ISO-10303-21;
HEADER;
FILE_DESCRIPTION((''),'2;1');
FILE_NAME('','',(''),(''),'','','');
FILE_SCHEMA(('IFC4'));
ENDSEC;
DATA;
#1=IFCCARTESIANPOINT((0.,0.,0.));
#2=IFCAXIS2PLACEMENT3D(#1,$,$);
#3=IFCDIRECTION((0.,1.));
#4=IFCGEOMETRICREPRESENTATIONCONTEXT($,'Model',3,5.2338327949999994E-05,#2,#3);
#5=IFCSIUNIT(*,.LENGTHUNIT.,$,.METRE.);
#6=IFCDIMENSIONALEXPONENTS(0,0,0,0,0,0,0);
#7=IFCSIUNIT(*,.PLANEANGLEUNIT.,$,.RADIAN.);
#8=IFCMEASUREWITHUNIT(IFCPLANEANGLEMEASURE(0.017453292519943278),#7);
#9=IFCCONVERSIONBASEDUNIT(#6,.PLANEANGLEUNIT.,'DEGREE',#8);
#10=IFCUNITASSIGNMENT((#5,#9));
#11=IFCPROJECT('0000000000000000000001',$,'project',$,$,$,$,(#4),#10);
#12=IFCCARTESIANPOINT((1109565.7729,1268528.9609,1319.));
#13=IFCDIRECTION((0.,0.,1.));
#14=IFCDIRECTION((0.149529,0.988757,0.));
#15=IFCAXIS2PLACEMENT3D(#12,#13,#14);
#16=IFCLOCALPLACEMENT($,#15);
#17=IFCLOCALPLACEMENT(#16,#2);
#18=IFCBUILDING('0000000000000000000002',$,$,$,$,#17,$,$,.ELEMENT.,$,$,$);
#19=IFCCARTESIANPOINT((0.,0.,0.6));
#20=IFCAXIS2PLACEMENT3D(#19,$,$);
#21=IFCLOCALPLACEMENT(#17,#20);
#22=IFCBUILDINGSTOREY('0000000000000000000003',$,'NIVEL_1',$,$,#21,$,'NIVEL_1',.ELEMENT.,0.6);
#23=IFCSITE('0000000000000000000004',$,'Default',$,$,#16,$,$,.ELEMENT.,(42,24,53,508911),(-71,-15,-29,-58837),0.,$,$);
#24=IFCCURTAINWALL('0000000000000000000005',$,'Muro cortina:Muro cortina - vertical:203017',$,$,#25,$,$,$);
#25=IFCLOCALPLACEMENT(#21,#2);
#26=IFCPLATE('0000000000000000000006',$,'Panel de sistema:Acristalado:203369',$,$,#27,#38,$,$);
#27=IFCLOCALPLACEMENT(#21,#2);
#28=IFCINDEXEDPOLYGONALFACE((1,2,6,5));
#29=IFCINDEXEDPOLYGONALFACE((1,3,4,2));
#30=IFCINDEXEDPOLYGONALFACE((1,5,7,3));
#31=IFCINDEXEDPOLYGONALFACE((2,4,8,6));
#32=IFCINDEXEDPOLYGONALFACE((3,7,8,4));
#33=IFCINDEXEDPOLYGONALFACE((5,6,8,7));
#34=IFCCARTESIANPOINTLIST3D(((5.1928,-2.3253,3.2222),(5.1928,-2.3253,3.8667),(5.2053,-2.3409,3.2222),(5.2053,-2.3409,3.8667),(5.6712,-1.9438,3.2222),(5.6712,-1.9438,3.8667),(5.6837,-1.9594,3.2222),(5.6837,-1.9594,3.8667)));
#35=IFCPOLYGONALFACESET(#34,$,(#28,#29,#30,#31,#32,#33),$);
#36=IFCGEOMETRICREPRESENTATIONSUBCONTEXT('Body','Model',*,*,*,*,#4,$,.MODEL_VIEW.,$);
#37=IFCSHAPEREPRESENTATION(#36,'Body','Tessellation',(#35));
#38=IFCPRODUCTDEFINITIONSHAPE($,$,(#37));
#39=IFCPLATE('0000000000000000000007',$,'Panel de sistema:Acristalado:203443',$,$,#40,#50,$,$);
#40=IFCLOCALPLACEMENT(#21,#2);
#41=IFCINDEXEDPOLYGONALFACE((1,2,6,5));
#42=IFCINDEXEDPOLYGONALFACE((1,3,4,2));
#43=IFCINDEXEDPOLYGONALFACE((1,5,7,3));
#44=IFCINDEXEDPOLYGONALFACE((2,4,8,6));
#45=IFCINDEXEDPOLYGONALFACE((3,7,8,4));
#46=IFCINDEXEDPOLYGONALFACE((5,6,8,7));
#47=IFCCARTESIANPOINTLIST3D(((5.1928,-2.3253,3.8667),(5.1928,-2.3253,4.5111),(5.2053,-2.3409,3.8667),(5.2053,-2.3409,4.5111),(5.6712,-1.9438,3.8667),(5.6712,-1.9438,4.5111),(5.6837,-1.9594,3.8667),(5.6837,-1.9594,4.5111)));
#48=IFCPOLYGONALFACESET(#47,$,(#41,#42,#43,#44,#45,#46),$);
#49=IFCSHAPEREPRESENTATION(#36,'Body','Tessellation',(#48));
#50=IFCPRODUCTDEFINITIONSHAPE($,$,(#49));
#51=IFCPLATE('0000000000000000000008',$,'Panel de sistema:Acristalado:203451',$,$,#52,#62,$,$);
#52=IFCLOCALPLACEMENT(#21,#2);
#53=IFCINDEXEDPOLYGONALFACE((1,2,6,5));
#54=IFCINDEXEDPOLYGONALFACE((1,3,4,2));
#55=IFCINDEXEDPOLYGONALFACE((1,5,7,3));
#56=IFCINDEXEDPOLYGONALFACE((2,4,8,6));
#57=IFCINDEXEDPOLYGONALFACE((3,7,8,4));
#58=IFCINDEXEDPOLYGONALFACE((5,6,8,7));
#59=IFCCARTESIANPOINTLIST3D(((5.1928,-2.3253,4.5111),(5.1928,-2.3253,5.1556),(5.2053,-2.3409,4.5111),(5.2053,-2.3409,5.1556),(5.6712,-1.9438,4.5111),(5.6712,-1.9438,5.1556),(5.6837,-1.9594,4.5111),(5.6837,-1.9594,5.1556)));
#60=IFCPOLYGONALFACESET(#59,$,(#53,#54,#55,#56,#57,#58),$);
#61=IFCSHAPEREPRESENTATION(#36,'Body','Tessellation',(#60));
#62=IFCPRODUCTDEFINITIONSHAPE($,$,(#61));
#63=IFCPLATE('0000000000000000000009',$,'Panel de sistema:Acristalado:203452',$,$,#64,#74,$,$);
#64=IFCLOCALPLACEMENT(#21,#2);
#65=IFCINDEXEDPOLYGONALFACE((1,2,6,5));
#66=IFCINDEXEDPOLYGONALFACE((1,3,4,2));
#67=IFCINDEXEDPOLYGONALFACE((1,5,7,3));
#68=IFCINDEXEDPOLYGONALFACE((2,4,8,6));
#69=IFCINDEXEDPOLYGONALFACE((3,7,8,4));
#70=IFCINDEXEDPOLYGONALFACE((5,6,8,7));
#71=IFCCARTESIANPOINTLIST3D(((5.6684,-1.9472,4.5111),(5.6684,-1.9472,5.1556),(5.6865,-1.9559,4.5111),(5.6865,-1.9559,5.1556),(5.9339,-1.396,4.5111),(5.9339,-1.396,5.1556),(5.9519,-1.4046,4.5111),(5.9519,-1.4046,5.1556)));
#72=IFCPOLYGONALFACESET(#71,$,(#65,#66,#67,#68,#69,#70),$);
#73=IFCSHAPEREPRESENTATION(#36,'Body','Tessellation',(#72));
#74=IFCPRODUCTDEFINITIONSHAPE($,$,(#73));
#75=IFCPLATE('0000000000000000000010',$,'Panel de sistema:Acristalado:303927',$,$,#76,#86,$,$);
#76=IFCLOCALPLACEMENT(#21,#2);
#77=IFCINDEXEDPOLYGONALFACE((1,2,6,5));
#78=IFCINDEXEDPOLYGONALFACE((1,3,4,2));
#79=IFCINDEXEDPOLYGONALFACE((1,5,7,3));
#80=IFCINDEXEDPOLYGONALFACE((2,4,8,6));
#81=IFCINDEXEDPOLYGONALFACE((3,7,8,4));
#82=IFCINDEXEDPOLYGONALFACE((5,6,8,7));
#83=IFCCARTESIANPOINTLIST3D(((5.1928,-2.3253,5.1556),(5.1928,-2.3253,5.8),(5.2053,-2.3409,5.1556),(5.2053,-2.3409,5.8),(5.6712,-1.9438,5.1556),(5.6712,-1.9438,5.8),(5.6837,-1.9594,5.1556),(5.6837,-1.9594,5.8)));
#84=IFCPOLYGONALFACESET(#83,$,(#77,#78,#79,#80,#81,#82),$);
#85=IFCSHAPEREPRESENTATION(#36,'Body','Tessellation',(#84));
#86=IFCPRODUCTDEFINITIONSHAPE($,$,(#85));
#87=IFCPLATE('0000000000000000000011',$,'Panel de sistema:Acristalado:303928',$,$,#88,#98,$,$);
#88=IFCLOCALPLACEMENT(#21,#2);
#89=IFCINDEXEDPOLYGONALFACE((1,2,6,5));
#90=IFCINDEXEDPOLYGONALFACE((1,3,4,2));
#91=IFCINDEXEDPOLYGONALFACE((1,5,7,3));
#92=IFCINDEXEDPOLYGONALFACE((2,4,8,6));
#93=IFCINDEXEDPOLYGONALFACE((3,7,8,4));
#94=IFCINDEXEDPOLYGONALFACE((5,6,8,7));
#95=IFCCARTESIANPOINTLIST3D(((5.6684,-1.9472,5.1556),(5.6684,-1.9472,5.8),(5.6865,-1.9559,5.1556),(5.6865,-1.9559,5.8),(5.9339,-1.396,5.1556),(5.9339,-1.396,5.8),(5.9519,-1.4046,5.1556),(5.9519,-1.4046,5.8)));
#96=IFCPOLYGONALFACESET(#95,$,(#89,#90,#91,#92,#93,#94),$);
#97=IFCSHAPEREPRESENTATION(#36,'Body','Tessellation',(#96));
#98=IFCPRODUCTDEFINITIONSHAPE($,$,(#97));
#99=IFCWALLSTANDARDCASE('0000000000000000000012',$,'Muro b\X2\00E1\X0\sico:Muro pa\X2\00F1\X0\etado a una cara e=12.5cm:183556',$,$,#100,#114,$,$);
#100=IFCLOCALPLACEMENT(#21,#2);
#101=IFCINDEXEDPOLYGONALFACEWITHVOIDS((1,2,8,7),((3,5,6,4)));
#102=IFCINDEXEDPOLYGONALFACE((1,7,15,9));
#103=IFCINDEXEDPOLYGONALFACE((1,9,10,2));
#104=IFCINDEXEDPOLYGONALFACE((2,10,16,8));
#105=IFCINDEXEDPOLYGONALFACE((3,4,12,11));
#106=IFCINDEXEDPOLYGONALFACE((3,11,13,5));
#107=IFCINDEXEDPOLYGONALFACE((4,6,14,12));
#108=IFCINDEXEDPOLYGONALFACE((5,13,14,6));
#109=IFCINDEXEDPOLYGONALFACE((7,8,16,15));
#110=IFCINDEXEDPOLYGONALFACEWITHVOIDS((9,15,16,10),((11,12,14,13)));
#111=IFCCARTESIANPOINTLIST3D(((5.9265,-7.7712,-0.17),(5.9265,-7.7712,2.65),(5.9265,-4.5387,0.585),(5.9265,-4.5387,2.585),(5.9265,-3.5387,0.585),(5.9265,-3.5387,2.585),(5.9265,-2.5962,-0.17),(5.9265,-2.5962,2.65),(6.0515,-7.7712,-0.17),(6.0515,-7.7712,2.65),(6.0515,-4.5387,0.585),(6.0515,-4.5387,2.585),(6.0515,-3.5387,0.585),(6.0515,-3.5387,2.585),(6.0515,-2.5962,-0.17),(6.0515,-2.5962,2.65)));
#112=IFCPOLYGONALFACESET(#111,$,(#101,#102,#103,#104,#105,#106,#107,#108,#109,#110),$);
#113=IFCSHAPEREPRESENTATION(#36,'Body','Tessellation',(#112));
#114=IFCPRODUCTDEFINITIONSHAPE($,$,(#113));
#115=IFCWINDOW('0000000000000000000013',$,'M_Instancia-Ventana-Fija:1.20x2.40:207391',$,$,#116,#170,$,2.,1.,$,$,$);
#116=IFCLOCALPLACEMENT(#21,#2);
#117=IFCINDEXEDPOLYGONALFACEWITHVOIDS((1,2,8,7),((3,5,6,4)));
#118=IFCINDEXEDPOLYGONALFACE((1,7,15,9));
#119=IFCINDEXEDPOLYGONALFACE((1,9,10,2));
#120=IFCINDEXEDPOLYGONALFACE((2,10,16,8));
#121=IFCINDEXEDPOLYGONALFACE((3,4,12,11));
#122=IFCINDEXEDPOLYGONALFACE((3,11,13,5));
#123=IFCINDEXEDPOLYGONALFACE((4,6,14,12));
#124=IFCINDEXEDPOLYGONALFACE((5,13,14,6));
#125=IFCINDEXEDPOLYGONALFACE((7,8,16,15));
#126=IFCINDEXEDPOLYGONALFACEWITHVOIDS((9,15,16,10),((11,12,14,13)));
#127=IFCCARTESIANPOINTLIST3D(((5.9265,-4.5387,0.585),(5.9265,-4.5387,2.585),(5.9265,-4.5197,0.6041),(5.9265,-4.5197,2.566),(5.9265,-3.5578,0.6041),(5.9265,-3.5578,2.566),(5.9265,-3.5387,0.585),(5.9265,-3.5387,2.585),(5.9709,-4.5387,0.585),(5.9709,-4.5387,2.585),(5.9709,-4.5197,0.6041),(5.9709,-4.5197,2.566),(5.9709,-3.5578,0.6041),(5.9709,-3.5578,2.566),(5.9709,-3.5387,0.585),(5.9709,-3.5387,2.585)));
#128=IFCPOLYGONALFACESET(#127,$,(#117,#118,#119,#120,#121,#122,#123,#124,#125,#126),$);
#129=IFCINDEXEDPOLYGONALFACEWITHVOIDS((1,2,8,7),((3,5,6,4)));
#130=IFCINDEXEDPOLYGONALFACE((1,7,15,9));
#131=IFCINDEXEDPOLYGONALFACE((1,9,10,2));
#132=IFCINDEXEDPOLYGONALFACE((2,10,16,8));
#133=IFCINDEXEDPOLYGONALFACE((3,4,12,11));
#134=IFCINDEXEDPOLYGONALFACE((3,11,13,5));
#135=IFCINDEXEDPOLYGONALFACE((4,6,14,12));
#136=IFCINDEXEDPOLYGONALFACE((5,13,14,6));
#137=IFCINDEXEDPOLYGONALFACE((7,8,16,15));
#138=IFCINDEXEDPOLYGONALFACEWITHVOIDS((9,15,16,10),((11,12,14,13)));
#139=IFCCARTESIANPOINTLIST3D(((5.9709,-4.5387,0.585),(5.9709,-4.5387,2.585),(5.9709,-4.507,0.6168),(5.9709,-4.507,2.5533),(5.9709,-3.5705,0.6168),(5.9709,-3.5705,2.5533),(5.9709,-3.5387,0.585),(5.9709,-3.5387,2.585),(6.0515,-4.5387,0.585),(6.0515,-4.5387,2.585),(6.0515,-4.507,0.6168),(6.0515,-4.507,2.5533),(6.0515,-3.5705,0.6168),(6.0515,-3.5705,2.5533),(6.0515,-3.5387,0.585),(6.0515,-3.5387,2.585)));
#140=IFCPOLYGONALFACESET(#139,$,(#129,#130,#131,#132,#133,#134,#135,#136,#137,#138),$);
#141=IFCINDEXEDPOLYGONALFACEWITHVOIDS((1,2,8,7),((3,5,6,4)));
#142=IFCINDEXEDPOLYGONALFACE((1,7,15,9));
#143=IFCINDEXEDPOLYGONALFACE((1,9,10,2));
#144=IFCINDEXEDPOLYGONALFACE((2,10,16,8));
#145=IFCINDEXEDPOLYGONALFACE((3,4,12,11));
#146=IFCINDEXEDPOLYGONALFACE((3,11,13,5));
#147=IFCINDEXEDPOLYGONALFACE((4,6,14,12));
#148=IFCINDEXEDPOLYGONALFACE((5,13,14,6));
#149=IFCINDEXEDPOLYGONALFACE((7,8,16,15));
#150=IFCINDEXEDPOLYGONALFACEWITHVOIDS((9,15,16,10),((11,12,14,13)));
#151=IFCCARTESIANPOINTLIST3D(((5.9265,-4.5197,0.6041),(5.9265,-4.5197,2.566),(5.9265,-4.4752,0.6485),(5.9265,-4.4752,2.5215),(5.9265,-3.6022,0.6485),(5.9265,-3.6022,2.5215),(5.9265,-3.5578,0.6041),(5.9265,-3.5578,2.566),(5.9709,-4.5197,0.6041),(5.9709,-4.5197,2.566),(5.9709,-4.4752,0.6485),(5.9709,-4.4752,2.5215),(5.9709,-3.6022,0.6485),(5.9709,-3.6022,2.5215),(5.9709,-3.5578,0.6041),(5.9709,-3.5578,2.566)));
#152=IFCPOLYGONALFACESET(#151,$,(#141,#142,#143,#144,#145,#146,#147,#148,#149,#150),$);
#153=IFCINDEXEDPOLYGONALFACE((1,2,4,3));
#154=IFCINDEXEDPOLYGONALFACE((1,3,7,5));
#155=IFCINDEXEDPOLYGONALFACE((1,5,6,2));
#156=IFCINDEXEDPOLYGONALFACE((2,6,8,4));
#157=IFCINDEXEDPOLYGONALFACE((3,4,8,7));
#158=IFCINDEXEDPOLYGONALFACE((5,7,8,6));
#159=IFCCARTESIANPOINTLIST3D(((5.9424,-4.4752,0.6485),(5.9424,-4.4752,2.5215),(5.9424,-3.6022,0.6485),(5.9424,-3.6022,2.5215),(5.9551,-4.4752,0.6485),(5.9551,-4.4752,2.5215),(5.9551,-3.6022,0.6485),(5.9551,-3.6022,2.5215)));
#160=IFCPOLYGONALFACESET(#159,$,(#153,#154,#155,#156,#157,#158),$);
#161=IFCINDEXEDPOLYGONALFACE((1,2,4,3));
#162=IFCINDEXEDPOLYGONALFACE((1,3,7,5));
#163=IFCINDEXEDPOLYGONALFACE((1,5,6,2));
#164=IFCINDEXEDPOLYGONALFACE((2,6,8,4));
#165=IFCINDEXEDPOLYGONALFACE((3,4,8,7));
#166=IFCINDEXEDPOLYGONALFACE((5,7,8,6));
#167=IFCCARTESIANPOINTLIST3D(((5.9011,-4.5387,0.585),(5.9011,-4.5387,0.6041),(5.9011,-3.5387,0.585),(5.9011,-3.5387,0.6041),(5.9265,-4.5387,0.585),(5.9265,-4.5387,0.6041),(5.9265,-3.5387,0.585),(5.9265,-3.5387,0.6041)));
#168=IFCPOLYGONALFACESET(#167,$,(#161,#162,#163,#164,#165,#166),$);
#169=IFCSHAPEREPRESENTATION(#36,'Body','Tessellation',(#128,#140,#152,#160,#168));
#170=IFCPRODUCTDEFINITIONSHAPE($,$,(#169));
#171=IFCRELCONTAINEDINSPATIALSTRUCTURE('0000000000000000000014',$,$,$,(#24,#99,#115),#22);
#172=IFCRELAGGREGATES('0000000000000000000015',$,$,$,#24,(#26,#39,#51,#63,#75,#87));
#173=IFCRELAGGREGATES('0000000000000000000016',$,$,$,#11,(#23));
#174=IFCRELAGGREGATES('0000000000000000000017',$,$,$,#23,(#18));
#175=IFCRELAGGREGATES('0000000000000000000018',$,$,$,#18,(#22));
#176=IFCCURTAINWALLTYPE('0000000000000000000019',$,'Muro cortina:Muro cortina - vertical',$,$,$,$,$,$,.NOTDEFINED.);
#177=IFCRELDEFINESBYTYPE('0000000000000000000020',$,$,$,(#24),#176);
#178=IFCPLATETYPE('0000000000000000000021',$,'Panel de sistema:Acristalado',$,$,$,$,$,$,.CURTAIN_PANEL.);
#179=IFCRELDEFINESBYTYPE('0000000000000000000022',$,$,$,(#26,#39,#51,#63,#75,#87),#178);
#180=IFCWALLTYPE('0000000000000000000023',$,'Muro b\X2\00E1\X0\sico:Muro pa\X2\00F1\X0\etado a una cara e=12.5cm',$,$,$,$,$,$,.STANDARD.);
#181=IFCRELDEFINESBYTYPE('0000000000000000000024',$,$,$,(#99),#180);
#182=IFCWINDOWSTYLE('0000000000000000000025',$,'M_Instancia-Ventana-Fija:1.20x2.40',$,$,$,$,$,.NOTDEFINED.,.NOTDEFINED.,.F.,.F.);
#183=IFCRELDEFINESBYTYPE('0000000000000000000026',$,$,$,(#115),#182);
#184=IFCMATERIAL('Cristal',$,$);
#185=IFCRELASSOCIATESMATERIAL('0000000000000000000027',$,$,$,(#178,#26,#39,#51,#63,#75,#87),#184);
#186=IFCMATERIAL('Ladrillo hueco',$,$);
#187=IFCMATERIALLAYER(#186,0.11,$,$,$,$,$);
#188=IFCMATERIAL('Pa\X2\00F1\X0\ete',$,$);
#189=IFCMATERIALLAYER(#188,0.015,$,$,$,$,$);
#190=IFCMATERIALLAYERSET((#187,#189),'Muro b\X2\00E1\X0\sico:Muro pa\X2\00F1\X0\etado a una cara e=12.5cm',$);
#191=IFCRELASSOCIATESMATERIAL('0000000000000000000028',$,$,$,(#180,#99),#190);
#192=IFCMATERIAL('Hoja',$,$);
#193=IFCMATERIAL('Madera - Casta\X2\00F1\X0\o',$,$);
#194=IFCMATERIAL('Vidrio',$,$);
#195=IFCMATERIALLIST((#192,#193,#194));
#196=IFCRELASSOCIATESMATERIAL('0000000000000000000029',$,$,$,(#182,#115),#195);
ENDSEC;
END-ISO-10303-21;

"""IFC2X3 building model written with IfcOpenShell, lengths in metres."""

from ifc_helpers import new_model, entity, si_unit, converted_unit, direction, frame, frame_2d, origin, origin_2d_with_axis, place, context, subcontext, project, spatial, polyline, rectangle, outline, extrude, source, transform, mapped, material, material_list, layer, layer_set, layer_usage, type_object, type_shapes, element, fill, aggregate, save


model = new_model("IFC2X3")

# Units and contexts
model_context = context("Model", 3, precision=5.2338327949999994e-05, world=origin(), true_north=direction((0.0, 1.0)))
body_context = subcontext(model_context, "Body", "Model", "MODEL_VIEW")
ifc_project = project(units=[si_unit("LENGTHUNIT", "METRE"), converted_unit("PLANEANGLEUNIT", "DEGREE", entity("IfcPlaneAngleMeasure", 0.017453292519943278), si_unit("PLANEANGLEUNIT", "RADIAN"), dimensions=[0, 0, 0, 0, 0, 0, 0])], contexts=[model_context])

# Site, building, storey
site_placement = place(None, frame((1109565.7729, 1268528.9609, 1319.0), z_axis=(0.0, 0.0, 1.0), x_axis=(0.149529, 0.988757, 0.0)))
site = spatial("IfcSite", under=ifc_project, at=site_placement, Name="Default", CompositionType="ELEMENT", RefLatitude=(42, 24, 53, 508911), RefLongitude=(-71, -15, -29, -58837), RefElevation=0.0)
building_placement = place(site_placement, origin())
building = spatial("IfcBuilding", under=site, at=building_placement, CompositionType="ELEMENT")
storey_placement = place(building_placement, frame((0.0, 0.0, 0.6)))
storey = spatial("IfcBuildingStorey", under=building, at=storey_placement, Name="NIVEL_1", LongName="NIVEL_1", CompositionType="ELEMENT", Elevation=0.6)

# Curtain wall, plates
curtain_wall_type = type_object("IfcCurtainWallType", Name="Muro cortina:Muro cortina - vertical", PredefinedType="NOTDEFINED")
curtain_wall_1_placement = place(storey_placement, frame((0.0, 0.0, -0.6)))
curtain_wall_1 = element("IfcCurtainWall", 1, at=curtain_wall_1_placement, inside=storey, type_object=curtain_wall_type, Name="Muro cortina:Muro cortina - vertical:203017")
ifc_material_1 = material(Name="Cristal")
plate_type_1 = type_object("IfcPlateType", Name="Panel de sistema:Acristalado", PredefinedType="CURTAIN_PANEL", material=ifc_material_1)
shared_shape_1 = source(origin(), body_context, "Body", "SweptSolid", [
    extrude(rectangle(XDim=0.02, YDim=0.6119, at=frame_2d((0.0, 0.0), x_axis=(1.0, 0.0))), frame((0.0, 0.0, 0.0), z_axis=(0.0, 0.0, 1.0), x_axis=(0.0, 1.0, 0.0)), (0.0, 0.0, 1.0), 0.6444),
])
type_shapes(plate_type_1, [shared_shape_1])
plate_1_placement = place(curtain_wall_1_placement, frame((5.4383, -2.1423, 3.8222), z_axis=(0.0, 0.0, 1.0), x_axis=(0.781832, 0.62349, 0.0)))
plate_1 = element("IfcPlate", 2, at=plate_1_placement, type_object=plate_type_1, material=ifc_material_1, Name="Panel de sistema:Acristalado:203369", context=body_context, shape_type="MappedRepresentation", body=[
    mapped(shared_shape_1, transform((0.0, 0.0, 0.0), scale=1.0)),
])
plate_2_placement = place(curtain_wall_1_placement, frame((5.4383, -2.1423, 4.4667), z_axis=(0.0, 0.0, 1.0), x_axis=(0.781832, 0.62349, 0.0)))
plate_2 = element("IfcPlate", 3, at=plate_2_placement, type_object=plate_type_1, material=ifc_material_1, Name="Panel de sistema:Acristalado:203443", context=body_context, shape_type="MappedRepresentation", body=[
    mapped(shared_shape_1, transform((0.0, 0.0, 0.0), scale=1.0)),
])
plate_3_placement = place(curtain_wall_1_placement, frame((5.4383, -2.1423, 5.1111), z_axis=(0.0, 0.0, 1.0), x_axis=(0.781832, 0.62349, 0.0)))
plate_3 = element("IfcPlate", 4, at=plate_3_placement, type_object=plate_type_1, material=ifc_material_1, Name="Panel de sistema:Acristalado:203451", context=body_context, shape_type="MappedRepresentation", body=[
    mapped(shared_shape_1, transform((0.0, 0.0, 0.0), scale=1.0)),
])
plate_4_placement = place(curtain_wall_1_placement, frame((5.8102, -1.6759, 5.1111), z_axis=(0.0, 0.0, 1.0), x_axis=(0.433884, 0.900969, 0.0)))
plate_4 = element("IfcPlate", 5, at=plate_4_placement, type_object=plate_type_1, material=ifc_material_1, Name="Panel de sistema:Acristalado:203452", context=body_context, shape_type="MappedRepresentation", body=[
    mapped(shared_shape_1, transform((0.0, 0.0, 0.0), scale=1.0)),
])
plate_5_placement = place(curtain_wall_1_placement, frame((5.4383, -2.1423, 5.7556), z_axis=(0.0, 0.0, 1.0), x_axis=(0.781832, 0.62349, 0.0)))
plate_5 = element("IfcPlate", 6, at=plate_5_placement, type_object=plate_type_1, material=ifc_material_1, Name="Panel de sistema:Acristalado:303927", context=body_context, shape_type="MappedRepresentation", body=[
    mapped(shared_shape_1, transform((0.0, 0.0, 0.0), scale=1.0)),
])
plate_6_placement = place(curtain_wall_1_placement, frame((5.8102, -1.6759, 5.7556), z_axis=(0.0, 0.0, 1.0), x_axis=(0.433884, 0.900969, 0.0)))
plate_6 = element("IfcPlate", 7, at=plate_6_placement, type_object=plate_type_1, material=ifc_material_1, Name="Panel de sistema:Acristalado:303928", context=body_context, shape_type="MappedRepresentation", body=[
    mapped(shared_shape_1, transform((0.0, 0.0, 0.0), scale=1.0)),
])
aggregate(curtain_wall_1, [plate_1, plate_2, plate_3, plate_4, plate_5, plate_6])

# Wall, opening, window
ifc_material_2 = material(Name="Ladrillo hueco")
ifc_layer_1 = layer(ifc_material_2, 0.11)
ifc_material_3 = material(Name="Pañete")
ifc_layer_2 = layer(ifc_material_3, 0.015)
ifc_layer_set_1 = layer_set([ifc_layer_1, ifc_layer_2], Name="Muro básico:Muro pañetado a una cara e=12.5cm")
ifc_layer_usage_1 = layer_usage(ifc_layer_set_1, "AXIS2", "POSITIVE", -0.0625)
wall_type_1 = type_object("IfcWallType", Name="Muro básico:Muro pañetado a una cara e=12.5cm", PredefinedType="STANDARD", material=ifc_layer_set_1)
wall_1_placement = place(storey_placement, frame((5.989, -7.7712, -0.17), z_axis=(0.0, 0.0, 1.0), x_axis=(0.0, 1.0, 0.0)))
wall_1 = element("IfcWallStandardCase", 8, at=wall_1_placement, inside=storey, type_object=wall_type_1, material=ifc_layer_usage_1, Name="Muro básico:Muro pañetado a una cara e=12.5cm:183556", context=body_context, shape_type="SweptSolid", body=[
    extrude(rectangle(XDim=5.175, YDim=0.125, at=frame_2d((2.5875, 0.0), x_axis=(-1.0, 0.0))), origin(), (0.0, 0.0, 1.0), 2.82),
])
opening_1_placement = place(wall_1_placement, frame((3.2325, -0.0625, 0.755)))
opening_1 = element("IfcOpeningElement", 9, at=opening_1_placement, cuts=wall_1, ObjectType="Opening", context=body_context, shape_type="SweptSolid", body=[
    extrude(rectangle(XDim=2.0, YDim=1.0, at=frame_2d((1.0, 0.5), x_axis=(-1.0, 0.0))), frame((0.0, 0.0, 0.0), z_axis=(0.0, 1.0, 0.0), x_axis=(0.0, 0.0, 1.0)), (0.0, 0.0, 1.0), 0.125),
])
ifc_material_4 = material(Name="Hoja")
ifc_material_5 = material(Name="Madera - Castaño")
ifc_material_6 = material(Name="Vidrio")
ifc_material_list = material_list([ifc_material_4, ifc_material_5, ifc_material_6])
window_style = type_object("IfcWindowStyle", Name="M_Instancia-Ventana-Fija:1.20x2.40", ConstructionType="NOTDEFINED", OperationType="NOTDEFINED", ParameterTakesPrecedence=False, Sizeable=False, material=ifc_material_list)
shared_shape_2 = source(origin(), body_context, "Body", "SweptSolid", [
    extrude(outline(polyline([(-1.0, -0.5), (1.0, -0.5), (1.0, 0.5), (-1.0, 0.5), (-1.0, -0.5)]), holes=[polyline([(-0.9809, -0.4809), (-0.9809, 0.481), (0.981, 0.481), (0.981, -0.4809), (-0.9809, -0.4809)])]), frame((0.5, 0.0806, 1.0), z_axis=(0.0, 1.0, 0.0), x_axis=(0.0, 0.0, -1.0)), (0.0, 0.0, 1.0), 0.0444),
    extrude(outline(polyline([(-0.5, -1.0), (0.5, -1.0), (0.5, 1.0), (-0.5, 1.0), (-0.5, -1.0)]), holes=[polyline([(-0.4683, -0.9682), (-0.4683, 0.9683), (0.4682, 0.9683), (0.4682, -0.9682), (-0.4683, -0.9682)])]), frame((0.5, 0.0, 1.0), z_axis=(0.0, 1.0, 0.0), x_axis=(1.0, 0.0, 0.0)), (0.0, 0.0, 1.0), 0.0806),
    extrude(outline(polyline([(-0.4809, -0.981), (0.4809, -0.981), (0.4809, 0.981), (-0.4809, 0.981), (-0.4809, -0.981)]), holes=[polyline([(-0.4365, -0.9365), (-0.4365, 0.9365), (0.4365, 0.9365), (0.4365, -0.9365), (-0.4365, -0.9365)])]), frame((0.5, 0.0806, 1.0), z_axis=(0.0, 1.0, 0.0), x_axis=(1.0, 0.0, 0.0)), (0.0, 0.0, 1.0), 0.0444),
    extrude(rectangle(XDim=0.0127, YDim=0.873, at=frame_2d((0.0, 0.0), x_axis=(1.0, 0.0))), frame((0.5, 0.1028, 0.0635), z_axis=(0.0, 0.0, 1.0), x_axis=(0.0, 1.0, 0.0)), (0.0, 0.0, 1.0), 1.873),
    extrude(rectangle(XDim=0.0254, YDim=1.0, at=origin_2d_with_axis()), frame((0.5, 0.1377, 0.0), z_axis=(0.0, 0.0, 1.0), x_axis=(0.0, -1.0, 0.0)), (0.0, 0.0, 1.0), 0.019),
])
type_shapes(window_style, [shared_shape_2])
window_placement = place(opening_1_placement, origin())
window = element("IfcWindow", 10, at=window_placement, inside=storey, type_object=window_style, material=ifc_material_list, Name="M_Instancia-Ventana-Fija:1.20x2.40:207391", OverallHeight=2.0, OverallWidth=1.0, context=body_context, shape_type="MappedRepresentation", body=[
    mapped(shared_shape_2, transform((0.0, 0.0, 0.0), scale=1.0)),
])
fill(opening_1, window)

save(model, "model.ifc")
